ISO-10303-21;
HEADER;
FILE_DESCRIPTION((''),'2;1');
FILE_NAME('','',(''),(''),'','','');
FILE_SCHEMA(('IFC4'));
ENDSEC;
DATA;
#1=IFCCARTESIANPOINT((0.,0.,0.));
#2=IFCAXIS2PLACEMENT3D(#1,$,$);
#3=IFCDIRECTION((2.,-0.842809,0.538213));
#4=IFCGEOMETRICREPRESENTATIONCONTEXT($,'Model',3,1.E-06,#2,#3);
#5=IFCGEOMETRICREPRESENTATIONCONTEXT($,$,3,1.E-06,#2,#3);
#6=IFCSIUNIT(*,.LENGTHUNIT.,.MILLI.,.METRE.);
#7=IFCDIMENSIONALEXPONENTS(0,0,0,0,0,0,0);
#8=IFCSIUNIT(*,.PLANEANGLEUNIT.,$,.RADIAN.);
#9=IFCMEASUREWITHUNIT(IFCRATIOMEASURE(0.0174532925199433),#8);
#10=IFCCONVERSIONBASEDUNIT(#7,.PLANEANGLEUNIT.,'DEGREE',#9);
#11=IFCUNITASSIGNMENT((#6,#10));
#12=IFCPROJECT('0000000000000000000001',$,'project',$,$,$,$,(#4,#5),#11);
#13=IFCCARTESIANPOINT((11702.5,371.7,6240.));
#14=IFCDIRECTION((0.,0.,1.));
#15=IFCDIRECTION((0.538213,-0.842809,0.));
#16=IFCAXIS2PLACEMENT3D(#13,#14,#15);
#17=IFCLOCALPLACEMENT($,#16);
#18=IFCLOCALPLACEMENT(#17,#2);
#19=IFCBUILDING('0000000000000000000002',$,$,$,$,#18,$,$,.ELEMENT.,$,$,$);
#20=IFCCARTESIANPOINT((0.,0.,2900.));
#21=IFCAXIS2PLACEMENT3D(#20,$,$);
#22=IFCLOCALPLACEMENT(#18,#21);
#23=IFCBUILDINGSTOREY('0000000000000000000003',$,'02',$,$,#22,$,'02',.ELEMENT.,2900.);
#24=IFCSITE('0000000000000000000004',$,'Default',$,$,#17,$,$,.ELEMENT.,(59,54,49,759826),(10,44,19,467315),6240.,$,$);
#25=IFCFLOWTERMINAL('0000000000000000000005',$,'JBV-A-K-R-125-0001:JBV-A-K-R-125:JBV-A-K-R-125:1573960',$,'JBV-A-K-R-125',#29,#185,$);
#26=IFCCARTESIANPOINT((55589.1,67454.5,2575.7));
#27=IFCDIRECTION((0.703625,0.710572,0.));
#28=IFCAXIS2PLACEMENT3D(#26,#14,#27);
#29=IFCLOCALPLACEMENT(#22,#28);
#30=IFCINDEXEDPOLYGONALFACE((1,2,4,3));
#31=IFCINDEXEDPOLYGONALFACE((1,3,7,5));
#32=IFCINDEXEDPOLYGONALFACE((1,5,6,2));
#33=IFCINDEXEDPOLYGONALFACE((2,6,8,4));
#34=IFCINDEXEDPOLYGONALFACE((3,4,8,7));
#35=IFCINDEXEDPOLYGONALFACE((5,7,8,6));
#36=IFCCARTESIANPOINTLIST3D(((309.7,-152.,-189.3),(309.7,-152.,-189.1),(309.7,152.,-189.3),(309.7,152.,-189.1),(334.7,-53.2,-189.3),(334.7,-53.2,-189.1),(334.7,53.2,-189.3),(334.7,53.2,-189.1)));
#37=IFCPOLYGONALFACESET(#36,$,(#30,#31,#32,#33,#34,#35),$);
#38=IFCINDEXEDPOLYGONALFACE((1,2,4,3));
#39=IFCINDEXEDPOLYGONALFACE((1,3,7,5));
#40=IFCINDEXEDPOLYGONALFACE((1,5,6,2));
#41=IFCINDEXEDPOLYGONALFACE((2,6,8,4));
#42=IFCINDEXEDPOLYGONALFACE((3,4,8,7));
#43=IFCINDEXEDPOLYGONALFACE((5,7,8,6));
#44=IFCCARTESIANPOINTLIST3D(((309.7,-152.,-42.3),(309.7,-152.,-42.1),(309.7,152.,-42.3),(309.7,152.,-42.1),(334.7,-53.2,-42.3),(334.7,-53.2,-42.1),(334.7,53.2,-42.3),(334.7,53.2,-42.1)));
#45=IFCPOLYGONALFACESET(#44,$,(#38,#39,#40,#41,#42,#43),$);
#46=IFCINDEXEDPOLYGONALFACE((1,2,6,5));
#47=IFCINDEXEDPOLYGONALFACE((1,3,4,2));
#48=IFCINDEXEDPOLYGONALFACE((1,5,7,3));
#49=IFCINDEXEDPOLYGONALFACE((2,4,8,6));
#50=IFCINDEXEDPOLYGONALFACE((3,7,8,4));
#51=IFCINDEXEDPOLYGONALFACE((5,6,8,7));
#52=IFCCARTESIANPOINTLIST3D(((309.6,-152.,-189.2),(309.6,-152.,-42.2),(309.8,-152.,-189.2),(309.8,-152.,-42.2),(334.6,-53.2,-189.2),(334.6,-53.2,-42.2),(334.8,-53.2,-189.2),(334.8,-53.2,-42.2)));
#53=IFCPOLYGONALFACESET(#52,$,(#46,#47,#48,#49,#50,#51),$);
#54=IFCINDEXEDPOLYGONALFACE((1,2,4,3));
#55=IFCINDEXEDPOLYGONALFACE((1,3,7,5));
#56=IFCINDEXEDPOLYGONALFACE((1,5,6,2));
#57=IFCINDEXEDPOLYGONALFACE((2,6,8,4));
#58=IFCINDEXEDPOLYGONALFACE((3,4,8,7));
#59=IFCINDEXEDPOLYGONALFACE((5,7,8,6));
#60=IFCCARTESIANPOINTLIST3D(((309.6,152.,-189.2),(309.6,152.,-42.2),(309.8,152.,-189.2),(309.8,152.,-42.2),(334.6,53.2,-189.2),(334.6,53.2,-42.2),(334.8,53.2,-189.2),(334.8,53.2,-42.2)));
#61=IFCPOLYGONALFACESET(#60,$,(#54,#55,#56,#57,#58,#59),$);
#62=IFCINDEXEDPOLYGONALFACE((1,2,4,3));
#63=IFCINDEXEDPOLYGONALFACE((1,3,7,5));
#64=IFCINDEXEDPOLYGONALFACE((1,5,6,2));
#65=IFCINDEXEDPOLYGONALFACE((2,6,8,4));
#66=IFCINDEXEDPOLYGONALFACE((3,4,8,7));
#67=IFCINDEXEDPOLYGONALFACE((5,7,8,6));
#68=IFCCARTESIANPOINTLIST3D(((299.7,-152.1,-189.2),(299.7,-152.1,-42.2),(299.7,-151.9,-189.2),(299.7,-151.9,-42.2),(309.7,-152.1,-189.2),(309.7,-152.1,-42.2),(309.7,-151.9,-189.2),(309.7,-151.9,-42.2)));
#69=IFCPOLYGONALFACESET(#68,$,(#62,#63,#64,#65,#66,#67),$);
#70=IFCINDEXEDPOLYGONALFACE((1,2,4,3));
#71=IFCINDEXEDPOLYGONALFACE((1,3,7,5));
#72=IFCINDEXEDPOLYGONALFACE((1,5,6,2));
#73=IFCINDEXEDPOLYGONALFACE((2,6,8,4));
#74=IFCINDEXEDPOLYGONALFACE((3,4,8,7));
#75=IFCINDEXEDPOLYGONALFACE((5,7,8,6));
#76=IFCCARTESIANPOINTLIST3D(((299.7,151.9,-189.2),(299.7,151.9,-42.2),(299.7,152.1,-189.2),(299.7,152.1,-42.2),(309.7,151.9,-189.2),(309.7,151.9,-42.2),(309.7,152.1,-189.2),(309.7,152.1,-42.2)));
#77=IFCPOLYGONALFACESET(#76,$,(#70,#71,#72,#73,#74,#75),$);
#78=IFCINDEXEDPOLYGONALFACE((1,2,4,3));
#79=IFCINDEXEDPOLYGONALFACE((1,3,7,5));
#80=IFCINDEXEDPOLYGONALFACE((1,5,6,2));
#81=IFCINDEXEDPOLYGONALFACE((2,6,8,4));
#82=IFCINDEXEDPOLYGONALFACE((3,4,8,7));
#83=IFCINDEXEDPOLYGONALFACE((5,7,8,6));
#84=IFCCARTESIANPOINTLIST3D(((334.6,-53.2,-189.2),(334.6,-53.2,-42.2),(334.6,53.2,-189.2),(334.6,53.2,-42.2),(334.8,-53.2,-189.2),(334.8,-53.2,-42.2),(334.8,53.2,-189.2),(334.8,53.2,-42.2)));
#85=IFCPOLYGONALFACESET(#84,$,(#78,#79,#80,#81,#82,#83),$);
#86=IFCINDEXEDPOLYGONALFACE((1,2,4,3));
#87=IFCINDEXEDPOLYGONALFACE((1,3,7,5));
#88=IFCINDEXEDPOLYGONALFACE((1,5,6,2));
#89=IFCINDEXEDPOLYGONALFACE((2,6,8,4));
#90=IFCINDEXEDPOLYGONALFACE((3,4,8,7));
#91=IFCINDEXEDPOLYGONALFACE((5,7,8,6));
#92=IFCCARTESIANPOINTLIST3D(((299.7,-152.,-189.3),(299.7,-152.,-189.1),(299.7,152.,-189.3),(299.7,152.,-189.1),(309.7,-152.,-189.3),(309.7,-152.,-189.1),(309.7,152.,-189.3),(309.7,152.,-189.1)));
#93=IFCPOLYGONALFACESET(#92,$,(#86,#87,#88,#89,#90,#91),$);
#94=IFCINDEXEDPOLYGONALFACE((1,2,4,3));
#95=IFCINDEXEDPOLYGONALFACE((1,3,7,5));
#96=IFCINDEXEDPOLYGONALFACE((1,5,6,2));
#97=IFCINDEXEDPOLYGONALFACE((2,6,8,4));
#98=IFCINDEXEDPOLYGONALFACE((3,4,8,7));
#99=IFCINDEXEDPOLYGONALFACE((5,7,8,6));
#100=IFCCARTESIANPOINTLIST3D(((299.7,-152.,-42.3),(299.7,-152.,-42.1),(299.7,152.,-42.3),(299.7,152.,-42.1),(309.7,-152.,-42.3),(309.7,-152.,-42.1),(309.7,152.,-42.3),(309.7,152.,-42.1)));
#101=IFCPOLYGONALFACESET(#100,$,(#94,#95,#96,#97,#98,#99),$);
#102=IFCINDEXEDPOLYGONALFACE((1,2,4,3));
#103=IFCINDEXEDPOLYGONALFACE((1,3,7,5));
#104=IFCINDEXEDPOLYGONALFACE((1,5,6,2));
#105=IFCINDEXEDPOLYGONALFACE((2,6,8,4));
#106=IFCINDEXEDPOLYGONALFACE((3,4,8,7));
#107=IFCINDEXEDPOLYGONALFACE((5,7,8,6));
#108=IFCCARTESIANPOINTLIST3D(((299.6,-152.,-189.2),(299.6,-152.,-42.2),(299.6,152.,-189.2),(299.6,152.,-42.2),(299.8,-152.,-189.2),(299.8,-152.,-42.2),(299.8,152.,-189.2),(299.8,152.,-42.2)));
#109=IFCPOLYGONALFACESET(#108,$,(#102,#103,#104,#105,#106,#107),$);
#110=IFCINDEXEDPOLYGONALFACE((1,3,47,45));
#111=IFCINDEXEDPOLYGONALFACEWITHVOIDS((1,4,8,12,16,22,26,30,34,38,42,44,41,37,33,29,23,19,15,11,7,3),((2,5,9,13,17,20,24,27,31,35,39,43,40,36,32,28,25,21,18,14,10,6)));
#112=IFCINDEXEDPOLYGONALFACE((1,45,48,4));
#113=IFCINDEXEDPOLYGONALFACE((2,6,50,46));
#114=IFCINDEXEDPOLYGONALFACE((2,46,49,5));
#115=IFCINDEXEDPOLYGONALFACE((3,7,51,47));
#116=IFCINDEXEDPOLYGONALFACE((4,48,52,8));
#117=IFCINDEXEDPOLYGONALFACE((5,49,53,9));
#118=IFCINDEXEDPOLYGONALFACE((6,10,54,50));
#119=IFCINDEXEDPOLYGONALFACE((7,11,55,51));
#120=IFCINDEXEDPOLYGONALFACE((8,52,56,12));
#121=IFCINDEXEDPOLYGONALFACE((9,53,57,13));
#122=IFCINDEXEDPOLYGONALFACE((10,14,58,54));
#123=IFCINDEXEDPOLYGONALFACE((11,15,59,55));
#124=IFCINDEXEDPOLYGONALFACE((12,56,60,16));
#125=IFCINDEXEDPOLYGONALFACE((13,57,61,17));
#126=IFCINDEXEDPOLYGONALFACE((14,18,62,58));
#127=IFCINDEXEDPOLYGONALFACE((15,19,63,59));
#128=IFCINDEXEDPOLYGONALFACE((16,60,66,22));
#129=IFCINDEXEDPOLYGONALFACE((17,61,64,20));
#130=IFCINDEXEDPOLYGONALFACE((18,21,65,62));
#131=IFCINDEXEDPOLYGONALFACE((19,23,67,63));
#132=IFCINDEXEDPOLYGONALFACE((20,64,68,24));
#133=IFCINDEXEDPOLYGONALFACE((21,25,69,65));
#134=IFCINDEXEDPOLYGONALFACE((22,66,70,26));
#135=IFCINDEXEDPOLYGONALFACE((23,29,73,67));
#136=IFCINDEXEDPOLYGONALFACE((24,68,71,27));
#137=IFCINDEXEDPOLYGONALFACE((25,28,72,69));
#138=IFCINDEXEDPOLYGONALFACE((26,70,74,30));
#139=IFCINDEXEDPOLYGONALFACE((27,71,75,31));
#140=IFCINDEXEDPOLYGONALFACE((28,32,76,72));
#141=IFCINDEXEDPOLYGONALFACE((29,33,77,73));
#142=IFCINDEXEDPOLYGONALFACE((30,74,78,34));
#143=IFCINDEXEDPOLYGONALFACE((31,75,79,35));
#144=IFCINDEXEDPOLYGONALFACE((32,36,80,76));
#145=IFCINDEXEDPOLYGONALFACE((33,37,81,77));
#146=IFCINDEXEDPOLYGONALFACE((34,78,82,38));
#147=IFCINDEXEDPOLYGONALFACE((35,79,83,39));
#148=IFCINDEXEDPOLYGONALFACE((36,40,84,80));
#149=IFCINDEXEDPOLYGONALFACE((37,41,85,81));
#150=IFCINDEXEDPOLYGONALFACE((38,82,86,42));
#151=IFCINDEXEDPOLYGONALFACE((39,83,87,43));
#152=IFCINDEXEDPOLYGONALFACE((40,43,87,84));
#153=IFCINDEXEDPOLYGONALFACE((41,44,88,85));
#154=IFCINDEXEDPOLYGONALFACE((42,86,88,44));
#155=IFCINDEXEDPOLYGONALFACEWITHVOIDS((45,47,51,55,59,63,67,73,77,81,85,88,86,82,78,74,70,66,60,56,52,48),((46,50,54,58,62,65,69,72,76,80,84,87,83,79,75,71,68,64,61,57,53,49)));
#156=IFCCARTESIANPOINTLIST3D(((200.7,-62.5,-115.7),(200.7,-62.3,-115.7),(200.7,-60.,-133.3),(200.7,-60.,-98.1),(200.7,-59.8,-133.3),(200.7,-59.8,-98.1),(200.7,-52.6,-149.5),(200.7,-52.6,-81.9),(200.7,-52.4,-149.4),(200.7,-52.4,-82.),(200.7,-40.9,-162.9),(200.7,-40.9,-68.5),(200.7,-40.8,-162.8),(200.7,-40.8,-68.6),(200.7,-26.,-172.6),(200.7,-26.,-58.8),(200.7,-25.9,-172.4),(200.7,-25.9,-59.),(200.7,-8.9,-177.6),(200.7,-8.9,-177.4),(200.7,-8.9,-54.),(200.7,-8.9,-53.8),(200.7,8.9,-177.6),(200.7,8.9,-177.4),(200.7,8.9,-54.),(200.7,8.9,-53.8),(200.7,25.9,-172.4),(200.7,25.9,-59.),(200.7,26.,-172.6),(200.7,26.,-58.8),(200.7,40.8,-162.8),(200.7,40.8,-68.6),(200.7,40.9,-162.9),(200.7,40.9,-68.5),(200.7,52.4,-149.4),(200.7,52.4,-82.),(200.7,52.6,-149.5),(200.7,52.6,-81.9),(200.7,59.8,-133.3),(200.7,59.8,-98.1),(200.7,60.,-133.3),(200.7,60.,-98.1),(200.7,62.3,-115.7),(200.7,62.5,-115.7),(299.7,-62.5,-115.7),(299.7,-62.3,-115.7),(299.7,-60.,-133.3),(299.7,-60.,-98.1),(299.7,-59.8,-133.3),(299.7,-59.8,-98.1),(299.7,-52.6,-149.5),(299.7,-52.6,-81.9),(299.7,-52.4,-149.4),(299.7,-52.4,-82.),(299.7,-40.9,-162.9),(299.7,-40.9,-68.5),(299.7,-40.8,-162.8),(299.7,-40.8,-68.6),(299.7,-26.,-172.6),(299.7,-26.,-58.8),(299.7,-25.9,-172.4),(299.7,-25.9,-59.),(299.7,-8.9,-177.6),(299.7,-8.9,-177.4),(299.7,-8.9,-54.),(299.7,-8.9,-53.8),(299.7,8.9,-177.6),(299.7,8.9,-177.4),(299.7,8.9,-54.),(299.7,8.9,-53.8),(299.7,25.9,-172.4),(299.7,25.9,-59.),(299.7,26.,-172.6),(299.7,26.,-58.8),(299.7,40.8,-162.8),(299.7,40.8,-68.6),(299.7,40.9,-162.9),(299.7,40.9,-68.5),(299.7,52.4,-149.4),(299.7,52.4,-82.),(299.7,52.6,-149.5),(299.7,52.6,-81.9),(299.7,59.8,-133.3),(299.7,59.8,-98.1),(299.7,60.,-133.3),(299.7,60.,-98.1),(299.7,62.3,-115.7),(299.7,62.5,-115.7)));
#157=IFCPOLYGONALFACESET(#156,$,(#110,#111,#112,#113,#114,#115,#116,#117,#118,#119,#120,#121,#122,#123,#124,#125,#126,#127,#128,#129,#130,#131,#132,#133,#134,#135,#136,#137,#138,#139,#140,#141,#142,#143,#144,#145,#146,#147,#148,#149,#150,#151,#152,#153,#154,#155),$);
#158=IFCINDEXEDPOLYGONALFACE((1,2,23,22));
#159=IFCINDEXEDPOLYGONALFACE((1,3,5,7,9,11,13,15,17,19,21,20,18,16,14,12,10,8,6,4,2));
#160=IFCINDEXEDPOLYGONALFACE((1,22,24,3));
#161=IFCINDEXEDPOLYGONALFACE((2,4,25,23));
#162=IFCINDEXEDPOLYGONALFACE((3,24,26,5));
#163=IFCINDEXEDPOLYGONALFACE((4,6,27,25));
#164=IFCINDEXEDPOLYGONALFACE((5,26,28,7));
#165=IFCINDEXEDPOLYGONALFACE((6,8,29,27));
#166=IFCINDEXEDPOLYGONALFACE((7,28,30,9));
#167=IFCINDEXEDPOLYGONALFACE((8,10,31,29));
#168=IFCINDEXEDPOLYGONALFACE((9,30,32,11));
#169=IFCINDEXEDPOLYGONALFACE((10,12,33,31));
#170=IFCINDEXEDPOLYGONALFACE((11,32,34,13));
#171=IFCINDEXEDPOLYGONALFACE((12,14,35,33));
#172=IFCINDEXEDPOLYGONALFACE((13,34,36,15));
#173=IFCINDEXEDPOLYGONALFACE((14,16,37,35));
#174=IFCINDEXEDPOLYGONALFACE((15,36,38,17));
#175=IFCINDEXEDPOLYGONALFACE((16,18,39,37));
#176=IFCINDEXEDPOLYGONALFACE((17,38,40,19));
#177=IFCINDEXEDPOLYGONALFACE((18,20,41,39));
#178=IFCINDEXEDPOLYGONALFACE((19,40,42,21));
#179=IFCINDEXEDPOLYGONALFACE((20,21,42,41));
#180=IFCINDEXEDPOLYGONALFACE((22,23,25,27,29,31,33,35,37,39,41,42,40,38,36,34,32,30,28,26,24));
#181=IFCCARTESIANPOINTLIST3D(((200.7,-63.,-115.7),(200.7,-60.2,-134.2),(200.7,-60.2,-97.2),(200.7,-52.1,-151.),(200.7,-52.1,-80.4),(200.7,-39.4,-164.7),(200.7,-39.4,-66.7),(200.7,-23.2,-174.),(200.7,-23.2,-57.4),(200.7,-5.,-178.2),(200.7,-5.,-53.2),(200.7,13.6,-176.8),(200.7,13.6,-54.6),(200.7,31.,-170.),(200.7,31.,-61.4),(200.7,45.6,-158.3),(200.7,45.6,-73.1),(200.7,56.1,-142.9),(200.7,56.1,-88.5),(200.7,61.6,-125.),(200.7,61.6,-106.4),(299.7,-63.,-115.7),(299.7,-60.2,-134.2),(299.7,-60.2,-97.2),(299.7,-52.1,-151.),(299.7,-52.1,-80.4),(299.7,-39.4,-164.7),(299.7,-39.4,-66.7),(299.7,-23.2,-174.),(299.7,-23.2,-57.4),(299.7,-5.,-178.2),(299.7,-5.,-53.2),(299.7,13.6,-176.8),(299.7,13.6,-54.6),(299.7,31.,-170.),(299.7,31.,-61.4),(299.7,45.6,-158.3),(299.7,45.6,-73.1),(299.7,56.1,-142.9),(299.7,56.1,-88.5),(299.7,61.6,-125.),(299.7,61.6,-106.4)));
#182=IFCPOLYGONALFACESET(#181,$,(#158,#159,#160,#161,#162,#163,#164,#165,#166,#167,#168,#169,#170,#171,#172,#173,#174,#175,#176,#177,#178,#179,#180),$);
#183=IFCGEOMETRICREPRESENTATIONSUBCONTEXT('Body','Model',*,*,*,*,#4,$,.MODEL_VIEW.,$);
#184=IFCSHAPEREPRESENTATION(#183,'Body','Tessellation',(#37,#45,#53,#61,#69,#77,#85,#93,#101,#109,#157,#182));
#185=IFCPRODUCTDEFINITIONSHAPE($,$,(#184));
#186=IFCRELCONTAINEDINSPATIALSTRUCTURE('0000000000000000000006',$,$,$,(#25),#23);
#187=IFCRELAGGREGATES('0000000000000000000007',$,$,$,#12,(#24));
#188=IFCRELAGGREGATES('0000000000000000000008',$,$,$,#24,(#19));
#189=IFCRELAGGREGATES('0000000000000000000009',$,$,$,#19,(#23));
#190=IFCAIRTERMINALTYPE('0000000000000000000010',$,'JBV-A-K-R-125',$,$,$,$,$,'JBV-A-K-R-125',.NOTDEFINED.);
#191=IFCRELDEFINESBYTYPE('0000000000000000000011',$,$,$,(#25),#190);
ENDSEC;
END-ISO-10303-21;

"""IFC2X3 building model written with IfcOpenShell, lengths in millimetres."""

from ifc_helpers import new_model, entity, si_unit, converted_unit, direction, frame, frame_2d, origin, origin_2d_with_axis, place, context, subcontext, project, spatial, polyline, circle_curve, parameter, trimmed, segment, composite_curve, rectangle, circle, outline, extrude, source, transform, mapped, type_object, type_shapes, element, save


model = new_model("IFC2X3")

# Units and contexts
model_context = context("Model", 3, precision=1e-06, world=origin(), true_north=direction((2.0, -0.842809, 0.538213)))
context_of_model = context(None, 3, precision=1e-06, world=origin(), true_north=direction((2.0, -0.842809, 0.538213)))
body_context = subcontext(model_context, "Body", "Model", "MODEL_VIEW")
ifc_project = project(units=[si_unit("LENGTHUNIT", "METRE", prefix="MILLI"), converted_unit("PLANEANGLEUNIT", "DEGREE", entity("IfcRatioMeasure", 0.0174532925199433), si_unit("PLANEANGLEUNIT", "RADIAN"), dimensions=[0, 0, 0, 0, 0, 0, 0])], contexts=[model_context, context_of_model])

# Site, building, storey
site_placement = place(None, frame((11702.5, 371.7, 6240.0), z_axis=(0.0, 0.0, 1.0), x_axis=(0.538213, -0.842809, 0.0)))
site = spatial("IfcSite", under=ifc_project, at=site_placement, Name="Default", CompositionType="ELEMENT", RefLatitude=(59, 54, 49, 759826), RefLongitude=(10, 44, 19, 467315), RefElevation=6240.0)
building_placement = place(site_placement, origin())
building = spatial("IfcBuilding", under=site, at=building_placement, CompositionType="ELEMENT")
storey_placement = place(building_placement, frame((0.0, 0.0, 2900.0)))
storey = spatial("IfcBuildingStorey", under=building, at=storey_placement, Name="02", LongName="02", CompositionType="ELEMENT", Elevation=2900.0)

# Flow terminal
air_terminal_type_1 = type_object("IfcAirTerminalType", Name="JBV-A-K-R-125", ElementType="JBV-A-K-R-125", PredefinedType="NOTDEFINED")
shared_shape_1 = source(origin(), body_context, "Body", "SweptSolid", [
    extrude(outline(polyline([(-150.4, -25.2), (-48.5, -25.2), (54.6, 0.9), (144.3, 49.4), (-150.4, -25.2)])), frame((322.2, 0.0, -189.3), z_axis=(0.0, 0.0, 1.0), x_axis=(0.245305, 0.969446, 0.0)), (0.0, 0.0, 1.0), 0.2),
    extrude(outline(polyline([(-150.4, -25.2), (-48.5, -25.2), (54.6, 0.9), (144.3, 49.4), (-150.4, -25.2)])), frame((322.2, 0.0, -42.3), z_axis=(0.0, 0.0, 1.0), x_axis=(0.245305, 0.969446, 0.0)), (0.0, 0.0, 1.0), 0.2),
    extrude(rectangle(XDim=101.9, YDim=0.2, at=frame_2d((0.0, 0.0), x_axis=(1.0, 0.0))), frame((322.2, -102.6, -189.2), z_axis=(0.0, 0.0, 1.0), x_axis=(-0.245305, -0.969446, 0.0)), (0.0, 0.0, 1.0), 147.0),
    extrude(rectangle(XDim=101.9, YDim=0.2, at=frame_2d((0.0, 0.0), x_axis=(1.0, 0.0))), frame((322.2, 102.6, -189.2), z_axis=(0.0, 0.0, 1.0), x_axis=(-0.245305, 0.969446, 0.0)), (0.0, 0.0, 1.0), 147.0),
    extrude(rectangle(XDim=10.0, YDim=0.2, at=frame_2d((0.0, 0.0), x_axis=(1.0, 0.0))), frame((304.7, -152.0, -189.2), z_axis=(0.0, 0.0, 1.0), x_axis=(-1.0, 0.0, 0.0)), (0.0, 0.0, 1.0), 147.0),
    extrude(rectangle(XDim=10.0, YDim=0.2, at=frame_2d((0.0, 0.0), x_axis=(1.0, 0.0))), frame((304.7, 152.0, -189.2), z_axis=(0.0, 0.0, 1.0), x_axis=(-1.0, 0.0, 0.0)), (0.0, 0.0, 1.0), 147.0),
    extrude(rectangle(XDim=106.4, YDim=0.2, at=frame_2d((0.0, 0.0), x_axis=(1.0, 0.0))), frame((334.7, 0.0, -189.2), z_axis=(0.0, 0.0, 1.0), x_axis=(0.0, -1.0, 0.0)), (0.0, 0.0, 1.0), 147.0),
    extrude(rectangle(XDim=10.0, YDim=304.0, at=frame_2d((0.0, 0.0), x_axis=(1.0, 0.0))), frame((304.7, 0.0, -189.3)), (0.0, 0.0, 1.0), 0.2),
    extrude(rectangle(XDim=10.0, YDim=304.0, at=frame_2d((0.0, 0.0), x_axis=(1.0, 0.0))), frame((304.7, 0.0, -42.3)), (0.0, 0.0, 1.0), 0.2),
    extrude(rectangle(XDim=304.0, YDim=0.2, at=frame_2d((0.0, 0.0), x_axis=(1.0, 0.0))), frame((299.7, 0.0, -189.2), z_axis=(0.0, 0.0, 1.0), x_axis=(0.0, -1.0, 0.0)), (0.0, 0.0, 1.0), 147.0),
    extrude(outline(composite_curve([segment(trimmed(circle_curve(origin_2d_with_axis(), 62.5), [parameter(0.0)], [parameter(180.0)], True, "PARAMETER"), True, "CONTINUOUS"), segment(trimmed(circle_curve(origin_2d_with_axis(), 62.5), [parameter(180.0)], [parameter(0.0)], True, "PARAMETER"), True, "CONTINUOUS")], self_intersect=False), holes=[composite_curve([segment(trimmed(circle_curve(origin_2d_with_axis(), 62.3), [parameter(180.0)], [parameter(360.0)], True, "PARAMETER"), False, "CONTINUOUS"), segment(trimmed(circle_curve(origin_2d_with_axis(), 62.3), [parameter(0.0)], [parameter(180.0)], True, "PARAMETER"), False, "CONTINUOUS")], self_intersect=False)]), frame((200.7, 0.0, -115.7), z_axis=(1.0, 0.0, 0.0), x_axis=(0.0, -1.0, 0.0)), (0.0, 0.0, 1.0), 99.0),
    extrude(circle(Radius=62.6, at=frame_2d((0.0, 0.0), x_axis=(1.0, 0.0))), frame((200.7, -0.3, -115.7), z_axis=(1.0, 0.0, 0.0), x_axis=(0.0, -1.0, 0.0)), (0.0, 0.0, 1.0), 99.0),
])
type_shapes(air_terminal_type_1, [shared_shape_1])
for number, where, z_axis, x_axis, name in (
    (1, (55589.1, 67454.5, 2575.7), (0.0, 0.0, 1.0), (0.703625, 0.710572, 0.0), "JBV-A-K-R-125-0001:JBV-A-K-R-125:JBV-A-K-R-125:1573960"),
):
    element("IfcFlowTerminal", number, at=place(storey_placement, frame(where, z_axis=z_axis, x_axis=x_axis)), inside=storey, type_object=air_terminal_type_1, Name=name, ObjectType="JBV-A-K-R-125", context=body_context, shape_type="MappedRepresentation", body=[
        mapped(shared_shape_1, transform((0.0, 0.0, 0.0), scale=1.0)),
    ])

save(model, "model.ifc")
